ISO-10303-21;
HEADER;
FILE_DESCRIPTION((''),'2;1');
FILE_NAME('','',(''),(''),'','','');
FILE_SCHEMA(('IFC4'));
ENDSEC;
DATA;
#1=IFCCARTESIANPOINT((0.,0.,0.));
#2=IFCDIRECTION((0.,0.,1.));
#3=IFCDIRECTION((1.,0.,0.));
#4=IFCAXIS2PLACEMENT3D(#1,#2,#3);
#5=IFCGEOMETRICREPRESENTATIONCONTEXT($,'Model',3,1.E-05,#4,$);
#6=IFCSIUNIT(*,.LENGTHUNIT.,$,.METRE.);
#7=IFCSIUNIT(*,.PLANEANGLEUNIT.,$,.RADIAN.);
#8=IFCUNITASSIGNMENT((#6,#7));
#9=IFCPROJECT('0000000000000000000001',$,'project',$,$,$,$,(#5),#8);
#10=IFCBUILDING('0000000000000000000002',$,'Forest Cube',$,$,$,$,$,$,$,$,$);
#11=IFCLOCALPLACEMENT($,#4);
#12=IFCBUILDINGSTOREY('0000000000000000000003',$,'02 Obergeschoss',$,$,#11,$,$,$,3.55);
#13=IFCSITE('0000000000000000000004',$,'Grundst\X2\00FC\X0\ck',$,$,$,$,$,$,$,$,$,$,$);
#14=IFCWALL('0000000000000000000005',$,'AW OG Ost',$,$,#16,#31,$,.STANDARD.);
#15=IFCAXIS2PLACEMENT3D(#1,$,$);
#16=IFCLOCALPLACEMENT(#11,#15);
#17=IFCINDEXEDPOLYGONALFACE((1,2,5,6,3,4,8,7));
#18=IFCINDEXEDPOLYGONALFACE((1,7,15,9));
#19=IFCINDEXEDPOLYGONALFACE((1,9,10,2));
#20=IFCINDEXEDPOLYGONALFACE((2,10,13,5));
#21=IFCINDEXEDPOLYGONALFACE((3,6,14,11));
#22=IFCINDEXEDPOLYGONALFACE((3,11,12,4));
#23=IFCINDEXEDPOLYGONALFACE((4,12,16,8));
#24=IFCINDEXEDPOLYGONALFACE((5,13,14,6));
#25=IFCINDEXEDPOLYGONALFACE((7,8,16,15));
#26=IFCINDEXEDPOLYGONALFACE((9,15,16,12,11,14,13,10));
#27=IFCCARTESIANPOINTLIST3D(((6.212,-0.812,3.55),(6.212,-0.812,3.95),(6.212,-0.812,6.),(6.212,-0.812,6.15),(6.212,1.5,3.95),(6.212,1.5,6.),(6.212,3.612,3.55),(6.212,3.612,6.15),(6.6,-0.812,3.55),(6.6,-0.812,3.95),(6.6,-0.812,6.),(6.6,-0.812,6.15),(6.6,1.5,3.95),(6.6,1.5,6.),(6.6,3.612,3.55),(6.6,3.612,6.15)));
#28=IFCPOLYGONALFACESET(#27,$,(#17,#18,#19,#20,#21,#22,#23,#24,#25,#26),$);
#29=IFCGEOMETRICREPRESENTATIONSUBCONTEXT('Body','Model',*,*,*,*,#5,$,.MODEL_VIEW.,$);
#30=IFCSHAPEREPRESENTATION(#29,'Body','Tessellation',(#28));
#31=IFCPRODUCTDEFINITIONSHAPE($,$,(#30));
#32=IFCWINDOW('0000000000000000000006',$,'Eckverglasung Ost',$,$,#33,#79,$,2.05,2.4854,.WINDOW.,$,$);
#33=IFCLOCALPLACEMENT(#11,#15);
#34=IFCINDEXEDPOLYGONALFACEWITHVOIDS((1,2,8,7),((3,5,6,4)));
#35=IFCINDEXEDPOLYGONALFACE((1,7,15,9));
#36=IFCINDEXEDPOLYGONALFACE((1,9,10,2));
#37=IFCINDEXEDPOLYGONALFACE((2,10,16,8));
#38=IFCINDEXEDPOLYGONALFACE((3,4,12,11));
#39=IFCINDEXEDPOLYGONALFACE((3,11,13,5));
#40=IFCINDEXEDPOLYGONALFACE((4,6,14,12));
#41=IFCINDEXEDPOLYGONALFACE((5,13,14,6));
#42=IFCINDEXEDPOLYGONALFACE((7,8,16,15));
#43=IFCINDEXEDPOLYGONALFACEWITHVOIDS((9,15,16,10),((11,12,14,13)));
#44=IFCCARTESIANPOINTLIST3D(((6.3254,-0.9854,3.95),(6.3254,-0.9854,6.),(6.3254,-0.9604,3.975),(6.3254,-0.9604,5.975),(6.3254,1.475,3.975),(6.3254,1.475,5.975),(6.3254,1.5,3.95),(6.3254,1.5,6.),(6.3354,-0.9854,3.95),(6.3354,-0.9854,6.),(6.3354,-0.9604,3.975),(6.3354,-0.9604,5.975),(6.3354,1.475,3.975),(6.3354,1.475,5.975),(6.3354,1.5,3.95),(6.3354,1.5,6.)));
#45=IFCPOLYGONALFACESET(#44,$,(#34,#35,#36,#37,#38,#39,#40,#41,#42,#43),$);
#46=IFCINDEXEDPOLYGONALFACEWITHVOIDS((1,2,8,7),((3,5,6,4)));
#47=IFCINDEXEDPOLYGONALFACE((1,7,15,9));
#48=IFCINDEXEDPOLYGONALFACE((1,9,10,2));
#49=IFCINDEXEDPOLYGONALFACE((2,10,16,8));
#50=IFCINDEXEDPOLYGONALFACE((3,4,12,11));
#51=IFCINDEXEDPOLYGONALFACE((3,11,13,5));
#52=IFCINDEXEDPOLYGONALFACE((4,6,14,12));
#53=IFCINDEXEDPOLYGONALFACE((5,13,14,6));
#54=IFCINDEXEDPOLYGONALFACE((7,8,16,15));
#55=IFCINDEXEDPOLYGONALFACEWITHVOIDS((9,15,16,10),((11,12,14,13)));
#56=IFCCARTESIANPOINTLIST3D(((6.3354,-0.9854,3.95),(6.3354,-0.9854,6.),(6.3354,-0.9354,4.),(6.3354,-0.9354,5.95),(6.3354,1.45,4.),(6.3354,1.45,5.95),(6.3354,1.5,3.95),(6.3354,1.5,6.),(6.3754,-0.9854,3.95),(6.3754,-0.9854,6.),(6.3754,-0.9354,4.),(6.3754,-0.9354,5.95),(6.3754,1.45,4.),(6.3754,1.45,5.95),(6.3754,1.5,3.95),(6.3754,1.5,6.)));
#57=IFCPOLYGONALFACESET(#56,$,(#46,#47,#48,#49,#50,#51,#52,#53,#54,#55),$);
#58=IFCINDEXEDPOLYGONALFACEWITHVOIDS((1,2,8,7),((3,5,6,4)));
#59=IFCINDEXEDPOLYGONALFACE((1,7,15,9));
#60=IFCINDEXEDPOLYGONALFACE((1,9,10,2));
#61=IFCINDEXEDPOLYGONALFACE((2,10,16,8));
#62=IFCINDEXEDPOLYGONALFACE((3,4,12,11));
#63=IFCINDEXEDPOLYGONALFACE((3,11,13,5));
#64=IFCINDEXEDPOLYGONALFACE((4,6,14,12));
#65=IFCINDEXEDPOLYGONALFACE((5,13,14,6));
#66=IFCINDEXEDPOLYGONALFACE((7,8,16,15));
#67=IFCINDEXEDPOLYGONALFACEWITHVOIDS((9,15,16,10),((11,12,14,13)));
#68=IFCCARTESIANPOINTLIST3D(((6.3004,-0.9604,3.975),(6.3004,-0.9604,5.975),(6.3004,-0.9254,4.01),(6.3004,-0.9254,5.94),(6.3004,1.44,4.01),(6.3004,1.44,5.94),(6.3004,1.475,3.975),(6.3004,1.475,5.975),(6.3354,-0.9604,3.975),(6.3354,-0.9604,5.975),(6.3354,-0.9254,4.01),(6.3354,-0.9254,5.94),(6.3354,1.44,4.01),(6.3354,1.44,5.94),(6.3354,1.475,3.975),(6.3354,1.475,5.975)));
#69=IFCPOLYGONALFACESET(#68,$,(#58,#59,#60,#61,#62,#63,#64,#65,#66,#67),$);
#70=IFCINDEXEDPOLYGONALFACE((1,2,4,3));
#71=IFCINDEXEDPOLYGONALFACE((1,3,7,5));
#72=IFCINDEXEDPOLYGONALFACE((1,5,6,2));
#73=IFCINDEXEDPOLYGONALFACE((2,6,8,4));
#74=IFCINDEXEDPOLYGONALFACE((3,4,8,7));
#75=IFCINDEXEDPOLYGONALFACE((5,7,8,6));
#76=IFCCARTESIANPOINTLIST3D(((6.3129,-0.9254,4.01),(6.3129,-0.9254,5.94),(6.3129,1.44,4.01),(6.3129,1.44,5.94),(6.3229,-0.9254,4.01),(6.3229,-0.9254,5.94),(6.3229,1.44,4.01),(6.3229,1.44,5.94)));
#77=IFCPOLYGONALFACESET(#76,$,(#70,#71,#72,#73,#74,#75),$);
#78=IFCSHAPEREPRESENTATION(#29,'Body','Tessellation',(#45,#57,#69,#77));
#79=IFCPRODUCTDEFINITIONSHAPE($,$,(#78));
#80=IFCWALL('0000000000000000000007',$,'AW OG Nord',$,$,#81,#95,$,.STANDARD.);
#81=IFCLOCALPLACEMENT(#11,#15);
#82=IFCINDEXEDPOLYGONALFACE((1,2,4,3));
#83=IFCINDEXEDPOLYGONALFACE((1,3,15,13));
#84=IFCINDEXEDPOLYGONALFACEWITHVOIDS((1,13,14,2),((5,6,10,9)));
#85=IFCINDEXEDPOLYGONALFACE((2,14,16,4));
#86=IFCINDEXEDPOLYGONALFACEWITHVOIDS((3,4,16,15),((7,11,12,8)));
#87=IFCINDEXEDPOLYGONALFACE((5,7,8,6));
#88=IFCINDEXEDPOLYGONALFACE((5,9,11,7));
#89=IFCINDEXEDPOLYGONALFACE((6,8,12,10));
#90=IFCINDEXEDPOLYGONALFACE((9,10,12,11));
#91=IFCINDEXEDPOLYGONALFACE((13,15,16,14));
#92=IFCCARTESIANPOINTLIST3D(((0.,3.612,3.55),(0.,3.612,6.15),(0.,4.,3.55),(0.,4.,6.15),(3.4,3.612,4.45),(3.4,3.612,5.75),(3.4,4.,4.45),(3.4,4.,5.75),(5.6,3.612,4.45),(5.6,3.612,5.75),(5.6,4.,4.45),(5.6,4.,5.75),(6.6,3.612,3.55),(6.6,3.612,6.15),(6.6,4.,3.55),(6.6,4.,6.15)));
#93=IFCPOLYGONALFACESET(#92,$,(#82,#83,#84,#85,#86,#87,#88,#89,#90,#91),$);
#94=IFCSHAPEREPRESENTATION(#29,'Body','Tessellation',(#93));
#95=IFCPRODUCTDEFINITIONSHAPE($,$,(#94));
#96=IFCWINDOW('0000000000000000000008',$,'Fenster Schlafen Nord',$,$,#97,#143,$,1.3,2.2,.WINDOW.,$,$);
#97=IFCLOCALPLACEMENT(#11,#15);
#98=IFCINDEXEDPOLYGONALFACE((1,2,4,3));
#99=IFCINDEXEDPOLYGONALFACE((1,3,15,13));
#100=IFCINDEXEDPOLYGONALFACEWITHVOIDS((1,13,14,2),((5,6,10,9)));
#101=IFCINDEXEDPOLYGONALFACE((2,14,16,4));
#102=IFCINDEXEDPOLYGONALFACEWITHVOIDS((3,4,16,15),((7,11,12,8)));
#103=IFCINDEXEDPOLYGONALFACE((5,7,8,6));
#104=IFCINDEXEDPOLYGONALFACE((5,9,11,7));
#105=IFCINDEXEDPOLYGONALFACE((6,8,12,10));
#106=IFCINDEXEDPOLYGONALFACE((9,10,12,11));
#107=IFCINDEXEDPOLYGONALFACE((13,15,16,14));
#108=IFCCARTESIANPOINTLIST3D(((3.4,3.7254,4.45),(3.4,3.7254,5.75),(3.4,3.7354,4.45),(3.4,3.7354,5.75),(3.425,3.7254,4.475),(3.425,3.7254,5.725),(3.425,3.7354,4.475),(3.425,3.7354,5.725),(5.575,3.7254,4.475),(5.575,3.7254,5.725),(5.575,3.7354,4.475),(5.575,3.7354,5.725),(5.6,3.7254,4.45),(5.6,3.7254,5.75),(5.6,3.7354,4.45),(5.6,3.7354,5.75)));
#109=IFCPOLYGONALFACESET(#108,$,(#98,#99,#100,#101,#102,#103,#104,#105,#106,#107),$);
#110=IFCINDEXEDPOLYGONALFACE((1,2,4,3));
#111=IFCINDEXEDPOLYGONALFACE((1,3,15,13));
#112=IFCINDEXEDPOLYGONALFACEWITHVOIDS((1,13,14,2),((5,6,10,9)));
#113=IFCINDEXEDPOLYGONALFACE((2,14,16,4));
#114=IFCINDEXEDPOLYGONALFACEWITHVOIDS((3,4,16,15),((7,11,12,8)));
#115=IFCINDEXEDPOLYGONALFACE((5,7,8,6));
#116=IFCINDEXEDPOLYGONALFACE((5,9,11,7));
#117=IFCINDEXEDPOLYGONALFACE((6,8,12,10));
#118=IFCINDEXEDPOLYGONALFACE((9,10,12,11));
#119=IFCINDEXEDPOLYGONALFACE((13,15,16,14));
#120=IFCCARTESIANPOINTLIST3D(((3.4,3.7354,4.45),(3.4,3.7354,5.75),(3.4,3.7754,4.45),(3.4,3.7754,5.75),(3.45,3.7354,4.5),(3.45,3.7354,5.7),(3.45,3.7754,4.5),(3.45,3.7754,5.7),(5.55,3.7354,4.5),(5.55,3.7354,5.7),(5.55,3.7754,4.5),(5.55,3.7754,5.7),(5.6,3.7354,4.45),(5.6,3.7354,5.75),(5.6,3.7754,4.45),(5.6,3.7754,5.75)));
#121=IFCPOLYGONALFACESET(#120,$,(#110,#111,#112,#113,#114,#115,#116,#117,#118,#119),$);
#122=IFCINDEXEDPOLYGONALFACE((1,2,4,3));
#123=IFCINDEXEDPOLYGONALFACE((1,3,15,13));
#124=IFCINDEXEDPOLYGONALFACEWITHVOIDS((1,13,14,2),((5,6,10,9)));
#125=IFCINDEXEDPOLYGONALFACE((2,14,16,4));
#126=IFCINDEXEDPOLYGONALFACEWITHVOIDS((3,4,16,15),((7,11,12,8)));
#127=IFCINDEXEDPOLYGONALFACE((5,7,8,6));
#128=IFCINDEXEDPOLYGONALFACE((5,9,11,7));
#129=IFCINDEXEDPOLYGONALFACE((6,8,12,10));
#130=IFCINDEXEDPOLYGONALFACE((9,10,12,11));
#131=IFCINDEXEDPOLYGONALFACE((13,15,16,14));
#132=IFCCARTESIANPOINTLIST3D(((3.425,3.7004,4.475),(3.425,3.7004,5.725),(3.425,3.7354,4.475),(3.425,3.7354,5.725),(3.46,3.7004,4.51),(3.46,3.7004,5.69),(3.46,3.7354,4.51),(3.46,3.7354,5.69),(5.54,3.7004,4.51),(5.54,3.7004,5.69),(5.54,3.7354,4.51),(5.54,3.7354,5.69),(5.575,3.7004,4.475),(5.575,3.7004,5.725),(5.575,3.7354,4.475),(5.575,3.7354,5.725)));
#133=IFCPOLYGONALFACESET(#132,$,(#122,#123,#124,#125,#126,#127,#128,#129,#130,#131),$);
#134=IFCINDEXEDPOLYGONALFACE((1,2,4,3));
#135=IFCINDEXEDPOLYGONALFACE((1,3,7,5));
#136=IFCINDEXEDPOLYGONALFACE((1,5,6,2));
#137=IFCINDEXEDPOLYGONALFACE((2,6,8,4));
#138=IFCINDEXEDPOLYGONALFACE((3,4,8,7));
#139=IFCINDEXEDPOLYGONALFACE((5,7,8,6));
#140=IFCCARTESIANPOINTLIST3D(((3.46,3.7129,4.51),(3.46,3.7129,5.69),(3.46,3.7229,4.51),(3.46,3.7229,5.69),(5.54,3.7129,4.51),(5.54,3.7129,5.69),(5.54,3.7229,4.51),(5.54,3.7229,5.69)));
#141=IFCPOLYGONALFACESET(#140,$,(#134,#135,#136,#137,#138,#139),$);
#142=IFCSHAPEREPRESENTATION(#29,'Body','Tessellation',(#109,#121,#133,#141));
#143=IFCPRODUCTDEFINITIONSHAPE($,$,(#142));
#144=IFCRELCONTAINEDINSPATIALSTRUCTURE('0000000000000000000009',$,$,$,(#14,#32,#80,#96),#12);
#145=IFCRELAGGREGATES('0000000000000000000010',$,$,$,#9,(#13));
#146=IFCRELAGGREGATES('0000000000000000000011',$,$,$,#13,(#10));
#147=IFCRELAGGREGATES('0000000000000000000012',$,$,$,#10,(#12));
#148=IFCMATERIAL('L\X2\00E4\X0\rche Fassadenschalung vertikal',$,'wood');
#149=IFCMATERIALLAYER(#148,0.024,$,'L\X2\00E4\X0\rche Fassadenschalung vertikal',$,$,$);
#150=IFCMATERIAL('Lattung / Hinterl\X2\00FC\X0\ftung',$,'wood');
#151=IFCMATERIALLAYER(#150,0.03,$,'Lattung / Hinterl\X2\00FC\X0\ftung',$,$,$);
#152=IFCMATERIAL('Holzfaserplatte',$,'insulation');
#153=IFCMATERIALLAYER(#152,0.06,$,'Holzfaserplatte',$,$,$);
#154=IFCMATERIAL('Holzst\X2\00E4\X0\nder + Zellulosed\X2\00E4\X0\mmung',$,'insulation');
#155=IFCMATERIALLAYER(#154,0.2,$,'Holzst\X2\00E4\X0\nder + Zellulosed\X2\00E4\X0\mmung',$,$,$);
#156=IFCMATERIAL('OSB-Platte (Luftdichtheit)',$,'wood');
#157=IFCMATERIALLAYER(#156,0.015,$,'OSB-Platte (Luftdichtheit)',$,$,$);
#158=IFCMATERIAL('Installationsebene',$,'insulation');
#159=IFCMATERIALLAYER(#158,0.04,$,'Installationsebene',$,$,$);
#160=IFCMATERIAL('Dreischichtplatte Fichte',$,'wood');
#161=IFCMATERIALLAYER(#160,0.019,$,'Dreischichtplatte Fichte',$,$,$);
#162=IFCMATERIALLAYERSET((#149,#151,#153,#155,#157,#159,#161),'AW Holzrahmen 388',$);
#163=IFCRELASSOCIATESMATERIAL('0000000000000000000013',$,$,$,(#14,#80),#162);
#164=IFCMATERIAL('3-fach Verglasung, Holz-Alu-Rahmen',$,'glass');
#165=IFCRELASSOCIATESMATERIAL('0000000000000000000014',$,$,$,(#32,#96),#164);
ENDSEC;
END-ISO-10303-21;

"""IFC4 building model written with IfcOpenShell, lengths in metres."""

from ifc_helpers import new_model, si_unit, frame, origin_with_axes, place, context, subcontext, project, spatial, line, indexed_curve, outline, extrude, material, layer, layer_set, element, fill, save


model = new_model("IFC4")

# Units and contexts
model_context = context("Model", 3, precision=1e-05, world=origin_with_axes())
body_context = subcontext(model_context, "Body", "Model", "MODEL_VIEW")
ifc_project = project(units=[si_unit("LENGTHUNIT", "METRE"), si_unit("PLANEANGLEUNIT", "RADIAN")], contexts=[model_context])

# Site, building, storey
site = spatial("IfcSite", under=ifc_project, Name="Grundstück")
building = spatial("IfcBuilding", under=site, Name="Forest Cube")
storey_placement = place(None, origin_with_axes())
storey = spatial("IfcBuildingStorey", under=building, at=storey_placement, Name="02 Obergeschoss", Elevation=3.55)

# Walls, openings, windows
ifc_material_1 = material(Name="Lärche Fassadenschalung vertikal", Category="wood")
ifc_layer_1 = layer(ifc_material_1, 0.024, Name="Lärche Fassadenschalung vertikal")
ifc_material_2 = material(Name="Lattung / Hinterlüftung", Category="wood")
ifc_layer_2 = layer(ifc_material_2, 0.03, Name="Lattung / Hinterlüftung")
ifc_material_3 = material(Name="Holzfaserplatte", Category="insulation")
ifc_layer_3 = layer(ifc_material_3, 0.06, Name="Holzfaserplatte")
ifc_material_4 = material(Name="Holzständer + Zellulosedämmung", Category="insulation")
ifc_layer_4 = layer(ifc_material_4, 0.2, Name="Holzständer + Zellulosedämmung")
ifc_material_5 = material(Name="OSB-Platte (Luftdichtheit)", Category="wood")
ifc_layer_5 = layer(ifc_material_5, 0.015, Name="OSB-Platte (Luftdichtheit)")
ifc_material_6 = material(Name="Installationsebene", Category="insulation")
ifc_layer_6 = layer(ifc_material_6, 0.04, Name="Installationsebene")
ifc_material_7 = material(Name="Dreischichtplatte Fichte", Category="wood")
ifc_layer_7 = layer(ifc_material_7, 0.019, Name="Dreischichtplatte Fichte")
ifc_layer_set_1 = layer_set([ifc_layer_1, ifc_layer_2, ifc_layer_3, ifc_layer_4, ifc_layer_5, ifc_layer_6, ifc_layer_7], Name="AW Holzrahmen 388")
ifc_material_8 = material(Name="3-fach Verglasung, Holz-Alu-Rahmen", Category="glass")
wall_1_placement = place(storey_placement, frame((6.6, -0.812, 3.55), z_axis=(0.0, 0.0, 1.0), x_axis=(0.0, 1.0, 0.0)))
wall_1 = element("IfcWall", 1, at=wall_1_placement, inside=storey, material=ifc_layer_set_1, Name="AW OG Ost", PredefinedType="STANDARD", context=body_context, shape_type="SweptSolid", body=[
    extrude(outline(indexed_curve([(0.0, 0.0), (0.0, 0.388), (4.424, 0.388), (4.424, 0.0), (0.0, 0.0)], self_intersect=False)), origin_with_axes(), (0.0, 0.0, 1.0), 2.6),
])
opening_1_placement = place(wall_1_placement, frame((0.0, -0.1, 0.4), z_axis=(0.0, 0.0, 1.0), x_axis=(1.0, 0.0, 0.0)))
opening_1 = element("IfcOpeningElement", 2, at=opening_1_placement, cuts=wall_1, context=body_context, shape_type="SweptSolid", body=[
    extrude(outline(indexed_curve([(0.0, 0.0), (0.0, 0.588), (2.312, 0.588), (2.312, 0.0), (0.0, 0.0)], self_intersect=False)), origin_with_axes(), (0.0, 0.0, 1.0), 2.05),
])
window_1_placement = place(storey_placement, frame((6.4254, -0.9854, 3.95), z_axis=(0.0, 0.0, 1.0), x_axis=(0.0, 1.0, 0.0)))
window_1 = element("IfcWindow", 3, at=window_1_placement, inside=storey, material=ifc_material_8, Name="Eckverglasung Ost", OverallHeight=2.05, OverallWidth=2.4854, PredefinedType="WINDOW", context=body_context, shape_type="SweptSolid", body=[
    extrude(outline(indexed_curve([(0.0, 0.0), (2.4854, 0.0), (2.4854, 2.05), (0.0, 2.05)], segments=[line(1, 2, 3, 4, 1)]), holes=[indexed_curve([(0.025, 0.025), (2.4604, 0.025), (2.4604, 2.025), (0.025, 2.025)], segments=[line(1, 2, 3, 4, 1)])]), frame((0.0, 0.09, 0.0), z_axis=(0.0, -1.0, 0.0), x_axis=(1.0, 0.0, 0.0)), (0.0, 0.0, -1.0), 0.01),
    extrude(outline(indexed_curve([(0.0, 0.0), (2.4854, 0.0), (2.4854, 2.05), (0.0, 2.05)], segments=[line(1, 2, 3, 4, 1)]), holes=[indexed_curve([(0.05, 0.05), (2.4354, 0.05), (2.4354, 2.0), (0.05, 2.0)], segments=[line(1, 2, 3, 4, 1)])]), frame((0.0, 0.05, 0.0), z_axis=(0.0, -1.0, 0.0), x_axis=(1.0, 0.0, 0.0)), (0.0, 0.0, -1.0), 0.04),
    extrude(outline(indexed_curve([(0.0, 0.0), (2.4354, 0.0), (2.4354, 2.0), (0.0, 2.0)], segments=[line(1, 2, 3, 4, 1)]), holes=[indexed_curve([(0.035, 0.035), (2.4004, 0.035), (2.4004, 1.965), (0.035, 1.965)], segments=[line(1, 2, 3, 4, 1)])]), frame((0.025, 0.09, 0.025), z_axis=(0.0, -1.0, 0.0), x_axis=(1.0, 0.0, 0.0)), (0.0, 0.0, -1.0), 0.035),
    extrude(outline(indexed_curve([(0.035, 0.035), (2.4004, 0.035), (2.4004, 1.965), (0.035, 1.965)], segments=[line(1, 2, 3, 4, 1)])), frame((0.025, 0.1025, 0.025), z_axis=(0.0, -1.0, 0.0), x_axis=(1.0, 0.0, 0.0)), (0.0, 0.0, -1.0), 0.01),
])
fill(opening_1, window_1)
wall_2_placement = place(storey_placement, frame((6.6, 4.0, 3.55), z_axis=(0.0, 0.0, 1.0), x_axis=(-1.0, 0.0, 0.0)))
wall_2 = element("IfcWall", 4, at=wall_2_placement, inside=storey, material=ifc_layer_set_1, Name="AW OG Nord", PredefinedType="STANDARD", context=body_context, shape_type="SweptSolid", body=[
    extrude(outline(indexed_curve([(0.0, 0.0), (0.0, 0.388), (6.6, 0.388), (6.6, 0.0), (0.0, 0.0)], self_intersect=False)), origin_with_axes(), (0.0, 0.0, 1.0), 2.6),
])
opening_2_placement = place(wall_2_placement, frame((1.0, -0.1, 0.9), z_axis=(0.0, 0.0, 1.0), x_axis=(1.0, 0.0, 0.0)))
opening_2 = element("IfcOpeningElement", 5, at=opening_2_placement, cuts=wall_2, context=body_context, shape_type="SweptSolid", body=[
    extrude(outline(indexed_curve([(0.0, 0.0), (0.0, 0.588), (2.2, 0.588), (2.2, 0.0), (0.0, 0.0)], self_intersect=False)), origin_with_axes(), (0.0, 0.0, 1.0), 1.3),
])
window_2_placement = place(storey_placement, frame((5.6, 3.8254, 4.45), z_axis=(0.0, 0.0, 1.0), x_axis=(-1.0, 0.0, 0.0)))
window_2 = element("IfcWindow", 6, at=window_2_placement, inside=storey, material=ifc_material_8, Name="Fenster Schlafen Nord", OverallHeight=1.3, OverallWidth=2.2, PredefinedType="WINDOW", context=body_context, shape_type="SweptSolid", body=[
    extrude(outline(indexed_curve([(0.0, 0.0), (2.2, 0.0), (2.2, 1.3), (0.0, 1.3)], segments=[line(1, 2, 3, 4, 1)]), holes=[indexed_curve([(0.025, 0.025), (2.175, 0.025), (2.175, 1.275), (0.025, 1.275)], segments=[line(1, 2, 3, 4, 1)])]), frame((0.0, 0.09, 0.0), z_axis=(0.0, -1.0, 0.0), x_axis=(1.0, 0.0, 0.0)), (0.0, 0.0, -1.0), 0.01),
    extrude(outline(indexed_curve([(0.0, 0.0), (2.2, 0.0), (2.2, 1.3), (0.0, 1.3)], segments=[line(1, 2, 3, 4, 1)]), holes=[indexed_curve([(0.05, 0.05), (2.15, 0.05), (2.15, 1.25), (0.05, 1.25)], segments=[line(1, 2, 3, 4, 1)])]), frame((0.0, 0.05, 0.0), z_axis=(0.0, -1.0, 0.0), x_axis=(1.0, 0.0, 0.0)), (0.0, 0.0, -1.0), 0.04),
    extrude(outline(indexed_curve([(0.0, 0.0), (2.15, 0.0), (2.15, 1.25), (0.0, 1.25)], segments=[line(1, 2, 3, 4, 1)]), holes=[indexed_curve([(0.035, 0.035), (2.115, 0.035), (2.115, 1.215), (0.035, 1.215)], segments=[line(1, 2, 3, 4, 1)])]), frame((0.025, 0.09, 0.025), z_axis=(0.0, -1.0, 0.0), x_axis=(1.0, 0.0, 0.0)), (0.0, 0.0, -1.0), 0.035),
    extrude(outline(indexed_curve([(0.035, 0.035), (2.115, 0.035), (2.115, 1.215), (0.035, 1.215)], segments=[line(1, 2, 3, 4, 1)])), frame((0.025, 0.1025, 0.025), z_axis=(0.0, -1.0, 0.0), x_axis=(1.0, 0.0, 0.0)), (0.0, 0.0, -1.0), 0.01),
])
fill(opening_2, window_2)

save(model, "model.ifc")
